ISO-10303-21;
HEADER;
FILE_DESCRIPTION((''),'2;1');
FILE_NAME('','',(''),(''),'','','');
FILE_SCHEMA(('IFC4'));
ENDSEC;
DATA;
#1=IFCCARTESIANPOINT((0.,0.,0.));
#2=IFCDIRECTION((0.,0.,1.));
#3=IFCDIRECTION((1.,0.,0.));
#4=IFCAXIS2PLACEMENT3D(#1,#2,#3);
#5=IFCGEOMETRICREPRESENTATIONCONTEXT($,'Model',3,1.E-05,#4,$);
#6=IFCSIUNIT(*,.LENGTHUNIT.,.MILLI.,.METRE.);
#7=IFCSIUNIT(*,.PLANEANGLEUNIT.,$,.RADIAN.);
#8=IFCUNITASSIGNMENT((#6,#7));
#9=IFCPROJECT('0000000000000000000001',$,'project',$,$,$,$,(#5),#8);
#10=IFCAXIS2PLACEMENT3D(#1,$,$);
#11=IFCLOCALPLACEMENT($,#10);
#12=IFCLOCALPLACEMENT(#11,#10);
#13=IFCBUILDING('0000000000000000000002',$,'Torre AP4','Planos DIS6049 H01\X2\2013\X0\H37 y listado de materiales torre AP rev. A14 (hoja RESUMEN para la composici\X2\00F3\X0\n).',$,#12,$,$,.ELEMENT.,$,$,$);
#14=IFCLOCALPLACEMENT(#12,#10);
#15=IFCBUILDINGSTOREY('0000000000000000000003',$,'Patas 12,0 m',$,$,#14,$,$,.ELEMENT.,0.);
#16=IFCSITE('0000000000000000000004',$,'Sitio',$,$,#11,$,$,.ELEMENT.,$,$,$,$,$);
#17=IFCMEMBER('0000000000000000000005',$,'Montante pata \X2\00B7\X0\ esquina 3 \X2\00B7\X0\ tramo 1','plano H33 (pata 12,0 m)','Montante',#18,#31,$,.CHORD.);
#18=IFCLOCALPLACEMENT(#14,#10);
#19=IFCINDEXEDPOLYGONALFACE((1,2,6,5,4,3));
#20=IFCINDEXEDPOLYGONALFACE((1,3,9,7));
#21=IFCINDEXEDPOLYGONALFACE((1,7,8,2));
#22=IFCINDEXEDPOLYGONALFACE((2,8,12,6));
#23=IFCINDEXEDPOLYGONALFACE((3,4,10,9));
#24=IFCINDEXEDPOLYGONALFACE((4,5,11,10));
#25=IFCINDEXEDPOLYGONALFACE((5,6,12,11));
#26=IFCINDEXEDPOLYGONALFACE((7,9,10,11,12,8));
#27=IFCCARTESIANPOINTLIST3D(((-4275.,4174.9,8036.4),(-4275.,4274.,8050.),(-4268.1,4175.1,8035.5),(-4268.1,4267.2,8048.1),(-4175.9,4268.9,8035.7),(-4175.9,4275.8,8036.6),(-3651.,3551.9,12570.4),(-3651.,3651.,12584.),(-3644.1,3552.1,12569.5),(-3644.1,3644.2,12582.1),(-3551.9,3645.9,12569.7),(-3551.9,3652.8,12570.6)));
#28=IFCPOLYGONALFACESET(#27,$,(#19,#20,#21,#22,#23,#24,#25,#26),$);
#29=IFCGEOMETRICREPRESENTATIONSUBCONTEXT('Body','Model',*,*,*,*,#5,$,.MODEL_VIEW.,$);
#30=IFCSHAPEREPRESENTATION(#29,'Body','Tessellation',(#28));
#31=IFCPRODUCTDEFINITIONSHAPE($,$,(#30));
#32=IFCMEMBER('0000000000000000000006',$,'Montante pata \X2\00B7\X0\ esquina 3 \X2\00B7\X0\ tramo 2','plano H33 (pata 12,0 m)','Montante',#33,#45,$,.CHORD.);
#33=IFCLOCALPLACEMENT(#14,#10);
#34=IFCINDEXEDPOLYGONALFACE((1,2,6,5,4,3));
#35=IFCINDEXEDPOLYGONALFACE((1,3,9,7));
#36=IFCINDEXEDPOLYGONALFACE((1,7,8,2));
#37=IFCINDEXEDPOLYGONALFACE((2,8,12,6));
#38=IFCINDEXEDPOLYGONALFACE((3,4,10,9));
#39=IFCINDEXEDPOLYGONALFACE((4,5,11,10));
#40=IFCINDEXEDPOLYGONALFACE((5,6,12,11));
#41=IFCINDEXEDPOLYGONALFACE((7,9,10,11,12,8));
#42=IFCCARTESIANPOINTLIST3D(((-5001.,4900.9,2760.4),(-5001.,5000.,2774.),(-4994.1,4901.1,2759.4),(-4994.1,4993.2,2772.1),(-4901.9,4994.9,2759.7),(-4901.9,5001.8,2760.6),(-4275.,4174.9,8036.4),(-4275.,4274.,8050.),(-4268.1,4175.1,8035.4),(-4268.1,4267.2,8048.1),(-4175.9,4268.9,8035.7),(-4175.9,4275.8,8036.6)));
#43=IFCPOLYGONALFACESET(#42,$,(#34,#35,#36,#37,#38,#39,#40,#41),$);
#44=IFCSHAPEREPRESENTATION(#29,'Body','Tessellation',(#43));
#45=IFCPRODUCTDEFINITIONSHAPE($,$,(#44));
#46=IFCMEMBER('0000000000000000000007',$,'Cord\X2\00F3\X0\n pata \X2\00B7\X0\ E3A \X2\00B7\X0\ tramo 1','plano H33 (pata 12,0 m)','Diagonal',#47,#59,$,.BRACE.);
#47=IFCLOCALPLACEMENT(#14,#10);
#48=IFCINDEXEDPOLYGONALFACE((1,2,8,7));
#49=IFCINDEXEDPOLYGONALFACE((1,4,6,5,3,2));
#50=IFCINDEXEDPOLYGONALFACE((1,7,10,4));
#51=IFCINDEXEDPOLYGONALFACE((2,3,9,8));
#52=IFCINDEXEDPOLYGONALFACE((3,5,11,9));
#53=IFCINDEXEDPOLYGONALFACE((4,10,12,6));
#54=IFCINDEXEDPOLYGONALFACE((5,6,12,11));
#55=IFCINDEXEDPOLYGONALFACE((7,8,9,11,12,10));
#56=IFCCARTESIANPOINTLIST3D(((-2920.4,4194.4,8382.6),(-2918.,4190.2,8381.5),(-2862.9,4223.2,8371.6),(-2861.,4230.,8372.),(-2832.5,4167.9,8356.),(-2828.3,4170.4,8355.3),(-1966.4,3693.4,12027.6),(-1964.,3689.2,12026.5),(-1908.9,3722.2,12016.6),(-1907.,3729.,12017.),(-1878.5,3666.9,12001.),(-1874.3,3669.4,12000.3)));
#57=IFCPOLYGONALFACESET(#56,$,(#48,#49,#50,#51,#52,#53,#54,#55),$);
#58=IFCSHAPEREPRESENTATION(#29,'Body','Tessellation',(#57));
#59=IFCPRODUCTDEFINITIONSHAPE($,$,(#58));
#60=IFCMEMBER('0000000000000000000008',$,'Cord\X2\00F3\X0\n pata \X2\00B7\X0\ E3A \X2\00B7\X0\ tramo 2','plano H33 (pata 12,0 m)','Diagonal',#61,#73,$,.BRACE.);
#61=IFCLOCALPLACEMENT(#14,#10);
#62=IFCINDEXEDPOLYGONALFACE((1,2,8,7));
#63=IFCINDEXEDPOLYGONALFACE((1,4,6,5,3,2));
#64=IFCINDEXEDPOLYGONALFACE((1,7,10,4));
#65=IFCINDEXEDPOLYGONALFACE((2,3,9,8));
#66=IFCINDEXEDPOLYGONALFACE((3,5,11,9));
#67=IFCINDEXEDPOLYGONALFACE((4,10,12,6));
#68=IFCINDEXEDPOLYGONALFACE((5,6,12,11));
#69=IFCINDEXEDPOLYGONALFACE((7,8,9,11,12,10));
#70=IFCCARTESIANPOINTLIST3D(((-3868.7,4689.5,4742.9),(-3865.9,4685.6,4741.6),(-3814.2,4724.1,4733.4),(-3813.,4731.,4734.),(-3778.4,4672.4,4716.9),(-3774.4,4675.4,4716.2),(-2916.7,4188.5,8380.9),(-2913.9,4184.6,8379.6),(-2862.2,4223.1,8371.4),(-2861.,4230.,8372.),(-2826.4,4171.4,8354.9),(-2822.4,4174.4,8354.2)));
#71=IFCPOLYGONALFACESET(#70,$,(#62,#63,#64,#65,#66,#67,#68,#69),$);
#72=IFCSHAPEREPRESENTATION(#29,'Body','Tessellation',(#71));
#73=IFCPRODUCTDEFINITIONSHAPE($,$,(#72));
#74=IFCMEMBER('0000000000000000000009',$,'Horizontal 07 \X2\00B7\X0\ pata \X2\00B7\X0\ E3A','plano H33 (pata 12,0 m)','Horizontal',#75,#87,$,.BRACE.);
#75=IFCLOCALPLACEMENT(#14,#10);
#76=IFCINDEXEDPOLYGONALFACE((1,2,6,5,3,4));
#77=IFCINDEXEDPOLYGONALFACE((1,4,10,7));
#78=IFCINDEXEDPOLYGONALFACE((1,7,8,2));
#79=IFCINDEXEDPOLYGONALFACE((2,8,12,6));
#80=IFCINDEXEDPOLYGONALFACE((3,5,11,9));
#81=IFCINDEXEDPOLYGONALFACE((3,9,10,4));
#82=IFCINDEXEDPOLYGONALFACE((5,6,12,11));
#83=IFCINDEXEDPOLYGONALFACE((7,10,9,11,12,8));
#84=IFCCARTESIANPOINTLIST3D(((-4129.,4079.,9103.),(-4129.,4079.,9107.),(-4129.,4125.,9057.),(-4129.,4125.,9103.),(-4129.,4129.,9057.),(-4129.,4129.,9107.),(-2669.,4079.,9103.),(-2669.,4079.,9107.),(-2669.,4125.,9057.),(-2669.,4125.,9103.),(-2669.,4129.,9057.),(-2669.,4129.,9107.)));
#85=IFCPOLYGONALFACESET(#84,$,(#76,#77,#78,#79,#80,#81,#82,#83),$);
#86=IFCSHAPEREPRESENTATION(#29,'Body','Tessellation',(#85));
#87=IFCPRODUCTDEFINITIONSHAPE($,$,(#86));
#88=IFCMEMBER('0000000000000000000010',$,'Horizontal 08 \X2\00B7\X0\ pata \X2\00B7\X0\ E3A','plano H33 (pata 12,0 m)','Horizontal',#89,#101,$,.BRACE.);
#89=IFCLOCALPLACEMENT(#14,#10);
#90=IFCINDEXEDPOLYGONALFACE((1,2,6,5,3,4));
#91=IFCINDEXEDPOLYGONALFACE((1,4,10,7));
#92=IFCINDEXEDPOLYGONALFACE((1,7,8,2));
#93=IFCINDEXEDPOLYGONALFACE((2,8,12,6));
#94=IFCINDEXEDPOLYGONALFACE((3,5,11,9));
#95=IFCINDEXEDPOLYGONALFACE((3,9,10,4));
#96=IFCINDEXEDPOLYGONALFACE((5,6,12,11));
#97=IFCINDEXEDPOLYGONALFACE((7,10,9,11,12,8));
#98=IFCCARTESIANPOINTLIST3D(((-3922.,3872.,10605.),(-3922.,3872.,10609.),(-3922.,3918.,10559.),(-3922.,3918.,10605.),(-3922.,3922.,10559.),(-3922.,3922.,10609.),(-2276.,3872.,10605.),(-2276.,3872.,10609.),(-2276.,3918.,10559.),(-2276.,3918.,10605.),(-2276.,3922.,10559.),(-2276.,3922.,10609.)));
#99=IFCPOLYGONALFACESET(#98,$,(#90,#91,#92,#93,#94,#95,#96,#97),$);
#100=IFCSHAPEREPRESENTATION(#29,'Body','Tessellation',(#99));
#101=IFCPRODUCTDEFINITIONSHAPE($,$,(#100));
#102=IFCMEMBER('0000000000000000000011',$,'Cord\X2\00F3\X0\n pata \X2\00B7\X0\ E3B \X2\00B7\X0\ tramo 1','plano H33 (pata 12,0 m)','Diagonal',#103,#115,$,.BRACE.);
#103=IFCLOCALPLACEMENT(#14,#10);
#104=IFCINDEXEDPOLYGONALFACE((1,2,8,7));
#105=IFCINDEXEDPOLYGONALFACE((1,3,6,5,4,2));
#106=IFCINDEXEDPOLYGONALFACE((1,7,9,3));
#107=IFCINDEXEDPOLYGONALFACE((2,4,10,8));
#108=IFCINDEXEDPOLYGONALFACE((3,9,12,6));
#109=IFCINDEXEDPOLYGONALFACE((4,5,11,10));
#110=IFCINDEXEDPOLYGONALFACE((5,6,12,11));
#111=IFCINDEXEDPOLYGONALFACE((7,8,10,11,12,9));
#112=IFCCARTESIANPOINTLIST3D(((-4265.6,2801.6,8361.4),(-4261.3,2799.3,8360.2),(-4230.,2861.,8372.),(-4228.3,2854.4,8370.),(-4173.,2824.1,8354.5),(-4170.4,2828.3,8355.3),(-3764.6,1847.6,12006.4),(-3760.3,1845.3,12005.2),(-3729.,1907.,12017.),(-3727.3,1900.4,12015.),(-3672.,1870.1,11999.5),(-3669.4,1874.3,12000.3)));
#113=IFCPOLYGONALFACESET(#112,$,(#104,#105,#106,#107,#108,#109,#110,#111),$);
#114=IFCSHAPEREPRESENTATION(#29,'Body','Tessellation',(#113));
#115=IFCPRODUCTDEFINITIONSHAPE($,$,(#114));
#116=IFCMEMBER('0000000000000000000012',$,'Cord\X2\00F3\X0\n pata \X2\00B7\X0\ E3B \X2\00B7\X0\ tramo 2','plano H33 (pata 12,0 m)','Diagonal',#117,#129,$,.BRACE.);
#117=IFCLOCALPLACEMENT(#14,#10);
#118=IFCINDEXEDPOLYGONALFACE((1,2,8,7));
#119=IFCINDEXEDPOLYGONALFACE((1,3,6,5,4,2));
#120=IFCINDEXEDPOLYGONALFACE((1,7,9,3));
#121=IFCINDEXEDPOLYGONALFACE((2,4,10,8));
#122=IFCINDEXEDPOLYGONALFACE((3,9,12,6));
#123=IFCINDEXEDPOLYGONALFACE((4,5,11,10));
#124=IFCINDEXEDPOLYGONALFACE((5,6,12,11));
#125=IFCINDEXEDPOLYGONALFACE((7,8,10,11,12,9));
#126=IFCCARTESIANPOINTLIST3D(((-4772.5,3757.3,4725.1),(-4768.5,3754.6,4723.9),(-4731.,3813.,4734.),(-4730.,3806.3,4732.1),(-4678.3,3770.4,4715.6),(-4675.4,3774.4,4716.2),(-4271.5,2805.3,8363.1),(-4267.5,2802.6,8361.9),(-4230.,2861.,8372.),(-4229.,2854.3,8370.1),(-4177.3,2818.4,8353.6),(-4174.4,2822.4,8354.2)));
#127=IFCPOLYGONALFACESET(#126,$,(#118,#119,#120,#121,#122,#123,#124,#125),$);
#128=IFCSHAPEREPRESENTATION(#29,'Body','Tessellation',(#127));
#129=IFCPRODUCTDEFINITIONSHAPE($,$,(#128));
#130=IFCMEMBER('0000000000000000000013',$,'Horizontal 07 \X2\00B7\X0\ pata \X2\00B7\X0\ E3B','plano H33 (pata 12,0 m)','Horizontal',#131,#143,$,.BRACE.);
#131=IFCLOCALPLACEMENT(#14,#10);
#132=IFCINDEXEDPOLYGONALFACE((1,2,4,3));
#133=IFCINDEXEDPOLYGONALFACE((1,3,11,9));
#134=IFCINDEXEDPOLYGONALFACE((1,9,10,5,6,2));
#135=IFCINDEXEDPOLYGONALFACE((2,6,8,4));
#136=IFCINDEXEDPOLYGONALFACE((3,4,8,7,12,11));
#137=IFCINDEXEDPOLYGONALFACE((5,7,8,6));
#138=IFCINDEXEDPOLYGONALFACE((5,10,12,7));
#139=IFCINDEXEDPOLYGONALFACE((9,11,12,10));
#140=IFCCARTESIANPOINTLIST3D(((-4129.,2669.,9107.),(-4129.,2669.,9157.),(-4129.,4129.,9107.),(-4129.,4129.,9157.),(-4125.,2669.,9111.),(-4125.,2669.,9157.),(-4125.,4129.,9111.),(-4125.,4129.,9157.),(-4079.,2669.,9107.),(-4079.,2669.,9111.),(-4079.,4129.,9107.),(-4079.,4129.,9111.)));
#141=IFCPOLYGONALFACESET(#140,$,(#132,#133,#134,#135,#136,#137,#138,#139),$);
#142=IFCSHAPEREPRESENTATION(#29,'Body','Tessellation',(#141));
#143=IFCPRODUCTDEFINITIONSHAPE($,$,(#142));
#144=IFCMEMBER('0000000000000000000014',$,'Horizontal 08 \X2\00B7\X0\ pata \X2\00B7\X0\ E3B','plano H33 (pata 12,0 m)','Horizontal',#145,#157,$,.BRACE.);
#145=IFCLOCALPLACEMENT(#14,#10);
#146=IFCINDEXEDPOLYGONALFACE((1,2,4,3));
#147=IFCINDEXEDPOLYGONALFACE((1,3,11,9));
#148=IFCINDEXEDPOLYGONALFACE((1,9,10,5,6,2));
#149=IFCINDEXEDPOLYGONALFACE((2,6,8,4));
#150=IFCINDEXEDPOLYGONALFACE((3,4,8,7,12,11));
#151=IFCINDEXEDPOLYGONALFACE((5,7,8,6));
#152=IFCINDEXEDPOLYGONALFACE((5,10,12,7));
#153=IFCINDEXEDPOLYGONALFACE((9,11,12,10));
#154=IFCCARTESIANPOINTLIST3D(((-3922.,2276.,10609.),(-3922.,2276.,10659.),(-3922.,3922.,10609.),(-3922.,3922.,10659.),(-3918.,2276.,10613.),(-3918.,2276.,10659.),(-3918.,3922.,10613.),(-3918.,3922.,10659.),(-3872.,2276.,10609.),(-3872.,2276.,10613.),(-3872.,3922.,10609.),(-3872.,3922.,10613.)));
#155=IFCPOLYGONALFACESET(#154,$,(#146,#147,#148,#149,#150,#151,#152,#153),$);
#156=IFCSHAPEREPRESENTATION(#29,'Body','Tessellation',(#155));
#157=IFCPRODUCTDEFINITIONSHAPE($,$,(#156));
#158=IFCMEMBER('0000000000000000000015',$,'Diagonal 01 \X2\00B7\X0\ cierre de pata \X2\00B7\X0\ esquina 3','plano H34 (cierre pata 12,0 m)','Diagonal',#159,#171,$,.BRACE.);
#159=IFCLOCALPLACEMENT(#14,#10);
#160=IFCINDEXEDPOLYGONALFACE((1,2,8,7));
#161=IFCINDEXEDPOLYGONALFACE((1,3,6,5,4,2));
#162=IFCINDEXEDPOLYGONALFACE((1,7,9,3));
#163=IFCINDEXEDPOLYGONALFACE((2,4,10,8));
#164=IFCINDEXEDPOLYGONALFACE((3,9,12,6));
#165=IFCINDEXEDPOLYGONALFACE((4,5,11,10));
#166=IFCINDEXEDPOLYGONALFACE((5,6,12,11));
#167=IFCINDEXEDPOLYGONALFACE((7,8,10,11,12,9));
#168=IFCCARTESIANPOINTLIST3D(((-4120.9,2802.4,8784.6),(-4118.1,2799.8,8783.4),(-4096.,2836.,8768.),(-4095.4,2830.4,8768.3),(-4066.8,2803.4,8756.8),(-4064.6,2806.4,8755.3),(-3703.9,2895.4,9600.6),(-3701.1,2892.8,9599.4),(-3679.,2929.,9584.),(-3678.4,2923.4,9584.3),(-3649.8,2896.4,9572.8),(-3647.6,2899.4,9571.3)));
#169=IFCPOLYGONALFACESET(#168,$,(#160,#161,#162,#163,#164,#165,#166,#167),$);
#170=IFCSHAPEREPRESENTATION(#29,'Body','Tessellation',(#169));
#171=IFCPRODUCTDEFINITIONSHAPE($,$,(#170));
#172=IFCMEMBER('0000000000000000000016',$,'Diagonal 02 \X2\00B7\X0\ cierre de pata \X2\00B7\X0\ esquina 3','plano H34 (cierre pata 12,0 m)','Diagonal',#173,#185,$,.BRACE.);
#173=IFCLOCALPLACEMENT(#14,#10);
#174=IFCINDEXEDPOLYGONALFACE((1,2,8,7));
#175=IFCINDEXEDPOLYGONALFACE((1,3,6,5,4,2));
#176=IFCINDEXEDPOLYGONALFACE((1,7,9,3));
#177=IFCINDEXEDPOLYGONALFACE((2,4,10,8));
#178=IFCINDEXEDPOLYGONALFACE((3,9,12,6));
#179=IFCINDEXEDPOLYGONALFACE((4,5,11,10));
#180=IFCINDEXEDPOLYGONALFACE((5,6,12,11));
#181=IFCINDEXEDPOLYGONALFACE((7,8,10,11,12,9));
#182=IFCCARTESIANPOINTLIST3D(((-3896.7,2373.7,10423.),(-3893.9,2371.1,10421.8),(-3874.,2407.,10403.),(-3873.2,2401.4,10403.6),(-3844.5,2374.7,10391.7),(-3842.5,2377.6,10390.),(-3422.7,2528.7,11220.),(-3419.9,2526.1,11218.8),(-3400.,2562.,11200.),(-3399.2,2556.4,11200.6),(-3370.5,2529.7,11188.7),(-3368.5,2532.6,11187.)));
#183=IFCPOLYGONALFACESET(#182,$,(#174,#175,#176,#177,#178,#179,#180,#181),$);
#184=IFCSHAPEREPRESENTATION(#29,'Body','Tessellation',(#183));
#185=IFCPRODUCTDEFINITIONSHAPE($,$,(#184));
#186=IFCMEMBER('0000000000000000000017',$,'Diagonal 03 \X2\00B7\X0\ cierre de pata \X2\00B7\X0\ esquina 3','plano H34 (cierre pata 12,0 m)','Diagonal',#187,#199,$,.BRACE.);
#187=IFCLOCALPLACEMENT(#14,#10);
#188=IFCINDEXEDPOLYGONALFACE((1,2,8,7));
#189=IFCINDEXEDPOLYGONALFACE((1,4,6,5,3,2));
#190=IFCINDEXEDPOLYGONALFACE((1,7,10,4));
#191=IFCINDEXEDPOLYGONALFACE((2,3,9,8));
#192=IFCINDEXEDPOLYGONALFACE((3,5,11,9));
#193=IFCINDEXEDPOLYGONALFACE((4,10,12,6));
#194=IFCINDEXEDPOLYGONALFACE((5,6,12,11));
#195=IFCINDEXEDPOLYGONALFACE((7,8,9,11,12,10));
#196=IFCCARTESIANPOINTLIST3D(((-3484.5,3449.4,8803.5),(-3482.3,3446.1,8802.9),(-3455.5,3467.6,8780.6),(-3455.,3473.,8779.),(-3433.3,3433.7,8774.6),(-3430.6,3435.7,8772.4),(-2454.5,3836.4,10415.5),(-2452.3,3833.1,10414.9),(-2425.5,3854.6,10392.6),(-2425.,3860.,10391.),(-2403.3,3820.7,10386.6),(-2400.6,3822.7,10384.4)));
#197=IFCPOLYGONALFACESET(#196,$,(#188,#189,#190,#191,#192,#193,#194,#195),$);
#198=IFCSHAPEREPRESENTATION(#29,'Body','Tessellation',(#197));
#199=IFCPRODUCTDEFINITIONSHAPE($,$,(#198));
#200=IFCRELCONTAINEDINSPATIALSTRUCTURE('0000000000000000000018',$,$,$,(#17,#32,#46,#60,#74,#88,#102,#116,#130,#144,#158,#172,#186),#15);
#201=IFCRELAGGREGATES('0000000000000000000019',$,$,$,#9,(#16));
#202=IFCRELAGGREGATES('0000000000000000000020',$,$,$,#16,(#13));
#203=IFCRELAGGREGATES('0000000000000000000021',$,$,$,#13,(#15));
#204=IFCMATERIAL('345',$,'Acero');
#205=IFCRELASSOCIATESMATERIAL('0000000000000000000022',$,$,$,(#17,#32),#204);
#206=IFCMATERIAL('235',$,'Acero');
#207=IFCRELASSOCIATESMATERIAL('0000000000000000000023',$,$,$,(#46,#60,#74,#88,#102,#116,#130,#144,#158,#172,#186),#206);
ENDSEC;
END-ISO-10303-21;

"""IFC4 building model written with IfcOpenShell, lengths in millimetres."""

from ifc_helpers import new_model, si_unit, frame, frame_2d, origin, origin_with_axes, place, context, subcontext, project, spatial, l_section, extrude, material, element, save


model = new_model("IFC4")

# Units and contexts
model_context = context("Model", 3, precision=1e-05, world=origin_with_axes())
body_context = subcontext(model_context, "Body", "Model", "MODEL_VIEW")
ifc_project = project(units=[si_unit("LENGTHUNIT", "METRE", prefix="MILLI"), si_unit("PLANEANGLEUNIT", "RADIAN")], contexts=[model_context])

# Site, building, storey
site_placement = place(None, origin())
site = spatial("IfcSite", under=ifc_project, at=site_placement, Name="Sitio", CompositionType="ELEMENT")
building_placement = place(site_placement, origin())
building = spatial("IfcBuilding", under=site, at=building_placement, Name="Torre AP4", Description="Planos DIS6049 H01–H37 y listado de materiales torre AP rev. A14 (hoja RESUMEN para la composición).", CompositionType="ELEMENT")
storey_placement = place(building_placement, origin())
storey = spatial("IfcBuildingStorey", under=building, at=storey_placement, Name="Patas 12,0 m", CompositionType="ELEMENT", Elevation=0.0)

# Members
ifc_material_1 = material(Name="345", Category="Acero")
member_1_placement = place(storey_placement, frame((-3651.0, 3651.0, 12584.0), z_axis=(-0.135096, 0.134879, -0.981609), x_axis=(0.990833, 0.01839, -0.133838)))
element("IfcMember", 1, at=member_1_placement, inside=storey, material=ifc_material_1, Name="Montante pata · esquina 3 · tramo 1", Description="plano H33 (pata 12,0 m)", ObjectType="Montante", PredefinedType="CHORD", context=body_context, shape_type="SweptSolid", body=[
    extrude(l_section(Depth=100.0, Width=100.0, Thickness=7.0, at=frame_2d((50.0, 50.0))), None, (0.0, 0.0, 1.0), 4618.9),
])
member_2_placement = place(storey_placement, frame((-4275.0, 4274.0, 8050.0), z_axis=(-0.13507, 0.13507, -0.981586), x_axis=(0.990836, 0.018413, -0.13381)))
element("IfcMember", 2, at=member_2_placement, inside=storey, material=ifc_material_1, Name="Montante pata · esquina 3 · tramo 2", Description="plano H33 (pata 12,0 m)", ObjectType="Montante", PredefinedType="CHORD", context=body_context, shape_type="SweptSolid", body=[
    extrude(l_section(Depth=100.0, Width=100.0, Thickness=7.0, at=frame_2d((50.0, 50.0))), None, (0.0, 0.0, 1.0), 5375.0),
])
ifc_material_2 = material(Name="235", Category="Acero")
member_3_placement = place(storey_placement, frame((-1907.0, 3729.0, 12017.0), z_axis=(-0.250991, 0.13181, -0.958973), x_axis=(0.467044, -0.851254, -0.239242)))
element("IfcMember", 3, at=member_3_placement, inside=storey, material=ifc_material_2, Name="Cordón pata · E3A · tramo 1", Description="plano H33 (pata 12,0 m)", ObjectType="Diagonal", PredefinedType="BRACE", context=body_context, shape_type="SweptSolid", body=[
    extrude(l_section(Depth=70.0, Width=70.0, Thickness=5.0, at=frame_2d((35.0, 35.0))), None, (0.0, 0.0, 1.0), 3800.9),
])
member_4_placement = place(storey_placement, frame((-2861.0, 4230.0, 8372.0), z_axis=(-0.250941, 0.13206, -0.958952), x_axis=(0.551475, -0.794662, -0.253747)))
element("IfcMember", 4, at=member_4_placement, inside=storey, material=ifc_material_2, Name="Cordón pata · E3A · tramo 2", Description="plano H33 (pata 12,0 m)", ObjectType="Diagonal", PredefinedType="BRACE", context=body_context, shape_type="SweptSolid", body=[
    extrude(l_section(Depth=70.0, Width=70.0, Thickness=5.0, at=frame_2d((35.0, 35.0))), None, (0.0, 0.0, 1.0), 3793.7),
])
member_5_placement = place(storey_placement, frame((-4129.0, 4129.0, 9107.0), z_axis=(1.0, 0.0, 0.0), x_axis=(0.0, -1.0, 0.0)))
element("IfcMember", 5, at=member_5_placement, inside=storey, material=ifc_material_2, Name="Horizontal 07 · pata · E3A", Description="plano H33 (pata 12,0 m)", ObjectType="Horizontal", PredefinedType="BRACE", context=body_context, shape_type="SweptSolid", body=[
    extrude(l_section(Depth=50.0, Width=50.0, Thickness=4.0, at=frame_2d((25.0, 25.0))), None, (0.0, 0.0, 1.0), 1460.0),
])
member_6_placement = place(storey_placement, frame((-3922.0, 3922.0, 10609.0), z_axis=(1.0, 0.0, 0.0), x_axis=(0.0, -1.0, 0.0)))
element("IfcMember", 6, at=member_6_placement, inside=storey, material=ifc_material_2, Name="Horizontal 08 · pata · E3A", Description="plano H33 (pata 12,0 m)", ObjectType="Horizontal", PredefinedType="BRACE", context=body_context, shape_type="SweptSolid", body=[
    extrude(l_section(Depth=50.0, Width=50.0, Thickness=4.0, at=frame_2d((25.0, 25.0))), None, (0.0, 0.0, 1.0), 1646.0),
])
member_7_placement = place(storey_placement, frame((-3729.0, 1907.0, 12017.0), z_axis=(-0.13181, 0.250991, -0.958973), x_axis=(0.851254, -0.467044, -0.239242)))
element("IfcMember", 7, at=member_7_placement, inside=storey, material=ifc_material_2, Name="Cordón pata · E3B · tramo 1", Description="plano H33 (pata 12,0 m)", ObjectType="Diagonal", PredefinedType="BRACE", context=body_context, shape_type="SweptSolid", body=[
    extrude(l_section(Depth=70.0, Width=70.0, Thickness=5.0, at=frame_2d((35.0, 35.0))), None, (0.0, 0.0, 1.0), 3800.9),
])
member_8_placement = place(storey_placement, frame((-4230.0, 2861.0, 8372.0), z_axis=(-0.13206, 0.250941, -0.958952), x_axis=(0.794662, -0.551475, -0.253747)))
element("IfcMember", 8, at=member_8_placement, inside=storey, material=ifc_material_2, Name="Cordón pata · E3B · tramo 2", Description="plano H33 (pata 12,0 m)", ObjectType="Diagonal", PredefinedType="BRACE", context=body_context, shape_type="SweptSolid", body=[
    extrude(l_section(Depth=70.0, Width=70.0, Thickness=5.0, at=frame_2d((35.0, 35.0))), None, (0.0, 0.0, 1.0), 3793.7),
])
member_9_placement = place(storey_placement, frame((-4129.0, 4129.0, 9107.0), z_axis=(0.0, -1.0, 0.0), x_axis=(1.0, 0.0, 0.0)))
element("IfcMember", 9, at=member_9_placement, inside=storey, material=ifc_material_2, Name="Horizontal 07 · pata · E3B", Description="plano H33 (pata 12,0 m)", ObjectType="Horizontal", PredefinedType="BRACE", context=body_context, shape_type="SweptSolid", body=[
    extrude(l_section(Depth=50.0, Width=50.0, Thickness=4.0, at=frame_2d((25.0, 25.0))), None, (0.0, 0.0, 1.0), 1460.0),
])
member_10_placement = place(storey_placement, frame((-3922.0, 3922.0, 10609.0), z_axis=(0.0, -1.0, 0.0), x_axis=(1.0, 0.0, 0.0)))
element("IfcMember", 10, at=member_10_placement, inside=storey, material=ifc_material_2, Name="Horizontal 08 · pata · E3B", Description="plano H33 (pata 12,0 m)", ObjectType="Horizontal", PredefinedType="BRACE", context=body_context, shape_type="SweptSolid", body=[
    extrude(l_section(Depth=50.0, Width=50.0, Thickness=4.0, at=frame_2d((25.0, 25.0))), None, (0.0, 0.0, 1.0), 1646.0),
])
member_11_placement = place(storey_placement, frame((-3679.0, 2929.0, 9584.0), z_axis=(-0.452728, -0.100968, -0.885914), x_axis=(0.698827, -0.657265, -0.282212)))
element("IfcMember", 11, at=member_11_placement, inside=storey, material=ifc_material_2, Name="Diagonal 01 · cierre de pata · esquina 3", Description="plano H34 (cierre pata 12,0 m)", ObjectType="Diagonal", PredefinedType="BRACE", context=body_context, shape_type="SweptSolid", body=[
    extrude(l_section(Depth=45.0, Width=45.0, Thickness=4.0, at=frame_2d((22.5, 22.5))), None, (0.0, 0.0, 1.0), 921.1),
])
member_12_placement = place(storey_placement, frame((-3400.0, 2562.0, 11200.0), z_axis=(-0.504167, -0.164865, -0.847724), x_axis=(0.700338, -0.65241, -0.289632)))
element("IfcMember", 12, at=member_12_placement, inside=storey, material=ifc_material_2, Name="Diagonal 02 · cierre de pata · esquina 3", Description="plano H34 (cierre pata 12,0 m)", ObjectType="Diagonal", PredefinedType="BRACE", context=body_context, shape_type="SweptSolid", body=[
    extrude(l_section(Depth=45.0, Width=45.0, Thickness=4.0, at=frame_2d((22.5, 22.5))), None, (0.0, 0.0, 1.0), 940.2),
])
member_13_placement = place(storey_placement, frame((-2425.0, 3860.0, 10391.0), z_axis=(-0.527739, -0.198287, -0.825938), x_axis=(0.541385, -0.827791, -0.14719)))
element("IfcMember", 13, at=member_13_placement, inside=storey, material=ifc_material_2, Name="Diagonal 03 · cierre de pata · esquina 3", Description="plano H34 (cierre pata 12,0 m)", ObjectType="Diagonal", PredefinedType="BRACE", context=body_context, shape_type="SweptSolid", body=[
    extrude(l_section(Depth=45.0, Width=45.0, Thickness=4.0, at=frame_2d((22.5, 22.5))), None, (0.0, 0.0, 1.0), 1951.7),
])

save(model, "model.ifc")
